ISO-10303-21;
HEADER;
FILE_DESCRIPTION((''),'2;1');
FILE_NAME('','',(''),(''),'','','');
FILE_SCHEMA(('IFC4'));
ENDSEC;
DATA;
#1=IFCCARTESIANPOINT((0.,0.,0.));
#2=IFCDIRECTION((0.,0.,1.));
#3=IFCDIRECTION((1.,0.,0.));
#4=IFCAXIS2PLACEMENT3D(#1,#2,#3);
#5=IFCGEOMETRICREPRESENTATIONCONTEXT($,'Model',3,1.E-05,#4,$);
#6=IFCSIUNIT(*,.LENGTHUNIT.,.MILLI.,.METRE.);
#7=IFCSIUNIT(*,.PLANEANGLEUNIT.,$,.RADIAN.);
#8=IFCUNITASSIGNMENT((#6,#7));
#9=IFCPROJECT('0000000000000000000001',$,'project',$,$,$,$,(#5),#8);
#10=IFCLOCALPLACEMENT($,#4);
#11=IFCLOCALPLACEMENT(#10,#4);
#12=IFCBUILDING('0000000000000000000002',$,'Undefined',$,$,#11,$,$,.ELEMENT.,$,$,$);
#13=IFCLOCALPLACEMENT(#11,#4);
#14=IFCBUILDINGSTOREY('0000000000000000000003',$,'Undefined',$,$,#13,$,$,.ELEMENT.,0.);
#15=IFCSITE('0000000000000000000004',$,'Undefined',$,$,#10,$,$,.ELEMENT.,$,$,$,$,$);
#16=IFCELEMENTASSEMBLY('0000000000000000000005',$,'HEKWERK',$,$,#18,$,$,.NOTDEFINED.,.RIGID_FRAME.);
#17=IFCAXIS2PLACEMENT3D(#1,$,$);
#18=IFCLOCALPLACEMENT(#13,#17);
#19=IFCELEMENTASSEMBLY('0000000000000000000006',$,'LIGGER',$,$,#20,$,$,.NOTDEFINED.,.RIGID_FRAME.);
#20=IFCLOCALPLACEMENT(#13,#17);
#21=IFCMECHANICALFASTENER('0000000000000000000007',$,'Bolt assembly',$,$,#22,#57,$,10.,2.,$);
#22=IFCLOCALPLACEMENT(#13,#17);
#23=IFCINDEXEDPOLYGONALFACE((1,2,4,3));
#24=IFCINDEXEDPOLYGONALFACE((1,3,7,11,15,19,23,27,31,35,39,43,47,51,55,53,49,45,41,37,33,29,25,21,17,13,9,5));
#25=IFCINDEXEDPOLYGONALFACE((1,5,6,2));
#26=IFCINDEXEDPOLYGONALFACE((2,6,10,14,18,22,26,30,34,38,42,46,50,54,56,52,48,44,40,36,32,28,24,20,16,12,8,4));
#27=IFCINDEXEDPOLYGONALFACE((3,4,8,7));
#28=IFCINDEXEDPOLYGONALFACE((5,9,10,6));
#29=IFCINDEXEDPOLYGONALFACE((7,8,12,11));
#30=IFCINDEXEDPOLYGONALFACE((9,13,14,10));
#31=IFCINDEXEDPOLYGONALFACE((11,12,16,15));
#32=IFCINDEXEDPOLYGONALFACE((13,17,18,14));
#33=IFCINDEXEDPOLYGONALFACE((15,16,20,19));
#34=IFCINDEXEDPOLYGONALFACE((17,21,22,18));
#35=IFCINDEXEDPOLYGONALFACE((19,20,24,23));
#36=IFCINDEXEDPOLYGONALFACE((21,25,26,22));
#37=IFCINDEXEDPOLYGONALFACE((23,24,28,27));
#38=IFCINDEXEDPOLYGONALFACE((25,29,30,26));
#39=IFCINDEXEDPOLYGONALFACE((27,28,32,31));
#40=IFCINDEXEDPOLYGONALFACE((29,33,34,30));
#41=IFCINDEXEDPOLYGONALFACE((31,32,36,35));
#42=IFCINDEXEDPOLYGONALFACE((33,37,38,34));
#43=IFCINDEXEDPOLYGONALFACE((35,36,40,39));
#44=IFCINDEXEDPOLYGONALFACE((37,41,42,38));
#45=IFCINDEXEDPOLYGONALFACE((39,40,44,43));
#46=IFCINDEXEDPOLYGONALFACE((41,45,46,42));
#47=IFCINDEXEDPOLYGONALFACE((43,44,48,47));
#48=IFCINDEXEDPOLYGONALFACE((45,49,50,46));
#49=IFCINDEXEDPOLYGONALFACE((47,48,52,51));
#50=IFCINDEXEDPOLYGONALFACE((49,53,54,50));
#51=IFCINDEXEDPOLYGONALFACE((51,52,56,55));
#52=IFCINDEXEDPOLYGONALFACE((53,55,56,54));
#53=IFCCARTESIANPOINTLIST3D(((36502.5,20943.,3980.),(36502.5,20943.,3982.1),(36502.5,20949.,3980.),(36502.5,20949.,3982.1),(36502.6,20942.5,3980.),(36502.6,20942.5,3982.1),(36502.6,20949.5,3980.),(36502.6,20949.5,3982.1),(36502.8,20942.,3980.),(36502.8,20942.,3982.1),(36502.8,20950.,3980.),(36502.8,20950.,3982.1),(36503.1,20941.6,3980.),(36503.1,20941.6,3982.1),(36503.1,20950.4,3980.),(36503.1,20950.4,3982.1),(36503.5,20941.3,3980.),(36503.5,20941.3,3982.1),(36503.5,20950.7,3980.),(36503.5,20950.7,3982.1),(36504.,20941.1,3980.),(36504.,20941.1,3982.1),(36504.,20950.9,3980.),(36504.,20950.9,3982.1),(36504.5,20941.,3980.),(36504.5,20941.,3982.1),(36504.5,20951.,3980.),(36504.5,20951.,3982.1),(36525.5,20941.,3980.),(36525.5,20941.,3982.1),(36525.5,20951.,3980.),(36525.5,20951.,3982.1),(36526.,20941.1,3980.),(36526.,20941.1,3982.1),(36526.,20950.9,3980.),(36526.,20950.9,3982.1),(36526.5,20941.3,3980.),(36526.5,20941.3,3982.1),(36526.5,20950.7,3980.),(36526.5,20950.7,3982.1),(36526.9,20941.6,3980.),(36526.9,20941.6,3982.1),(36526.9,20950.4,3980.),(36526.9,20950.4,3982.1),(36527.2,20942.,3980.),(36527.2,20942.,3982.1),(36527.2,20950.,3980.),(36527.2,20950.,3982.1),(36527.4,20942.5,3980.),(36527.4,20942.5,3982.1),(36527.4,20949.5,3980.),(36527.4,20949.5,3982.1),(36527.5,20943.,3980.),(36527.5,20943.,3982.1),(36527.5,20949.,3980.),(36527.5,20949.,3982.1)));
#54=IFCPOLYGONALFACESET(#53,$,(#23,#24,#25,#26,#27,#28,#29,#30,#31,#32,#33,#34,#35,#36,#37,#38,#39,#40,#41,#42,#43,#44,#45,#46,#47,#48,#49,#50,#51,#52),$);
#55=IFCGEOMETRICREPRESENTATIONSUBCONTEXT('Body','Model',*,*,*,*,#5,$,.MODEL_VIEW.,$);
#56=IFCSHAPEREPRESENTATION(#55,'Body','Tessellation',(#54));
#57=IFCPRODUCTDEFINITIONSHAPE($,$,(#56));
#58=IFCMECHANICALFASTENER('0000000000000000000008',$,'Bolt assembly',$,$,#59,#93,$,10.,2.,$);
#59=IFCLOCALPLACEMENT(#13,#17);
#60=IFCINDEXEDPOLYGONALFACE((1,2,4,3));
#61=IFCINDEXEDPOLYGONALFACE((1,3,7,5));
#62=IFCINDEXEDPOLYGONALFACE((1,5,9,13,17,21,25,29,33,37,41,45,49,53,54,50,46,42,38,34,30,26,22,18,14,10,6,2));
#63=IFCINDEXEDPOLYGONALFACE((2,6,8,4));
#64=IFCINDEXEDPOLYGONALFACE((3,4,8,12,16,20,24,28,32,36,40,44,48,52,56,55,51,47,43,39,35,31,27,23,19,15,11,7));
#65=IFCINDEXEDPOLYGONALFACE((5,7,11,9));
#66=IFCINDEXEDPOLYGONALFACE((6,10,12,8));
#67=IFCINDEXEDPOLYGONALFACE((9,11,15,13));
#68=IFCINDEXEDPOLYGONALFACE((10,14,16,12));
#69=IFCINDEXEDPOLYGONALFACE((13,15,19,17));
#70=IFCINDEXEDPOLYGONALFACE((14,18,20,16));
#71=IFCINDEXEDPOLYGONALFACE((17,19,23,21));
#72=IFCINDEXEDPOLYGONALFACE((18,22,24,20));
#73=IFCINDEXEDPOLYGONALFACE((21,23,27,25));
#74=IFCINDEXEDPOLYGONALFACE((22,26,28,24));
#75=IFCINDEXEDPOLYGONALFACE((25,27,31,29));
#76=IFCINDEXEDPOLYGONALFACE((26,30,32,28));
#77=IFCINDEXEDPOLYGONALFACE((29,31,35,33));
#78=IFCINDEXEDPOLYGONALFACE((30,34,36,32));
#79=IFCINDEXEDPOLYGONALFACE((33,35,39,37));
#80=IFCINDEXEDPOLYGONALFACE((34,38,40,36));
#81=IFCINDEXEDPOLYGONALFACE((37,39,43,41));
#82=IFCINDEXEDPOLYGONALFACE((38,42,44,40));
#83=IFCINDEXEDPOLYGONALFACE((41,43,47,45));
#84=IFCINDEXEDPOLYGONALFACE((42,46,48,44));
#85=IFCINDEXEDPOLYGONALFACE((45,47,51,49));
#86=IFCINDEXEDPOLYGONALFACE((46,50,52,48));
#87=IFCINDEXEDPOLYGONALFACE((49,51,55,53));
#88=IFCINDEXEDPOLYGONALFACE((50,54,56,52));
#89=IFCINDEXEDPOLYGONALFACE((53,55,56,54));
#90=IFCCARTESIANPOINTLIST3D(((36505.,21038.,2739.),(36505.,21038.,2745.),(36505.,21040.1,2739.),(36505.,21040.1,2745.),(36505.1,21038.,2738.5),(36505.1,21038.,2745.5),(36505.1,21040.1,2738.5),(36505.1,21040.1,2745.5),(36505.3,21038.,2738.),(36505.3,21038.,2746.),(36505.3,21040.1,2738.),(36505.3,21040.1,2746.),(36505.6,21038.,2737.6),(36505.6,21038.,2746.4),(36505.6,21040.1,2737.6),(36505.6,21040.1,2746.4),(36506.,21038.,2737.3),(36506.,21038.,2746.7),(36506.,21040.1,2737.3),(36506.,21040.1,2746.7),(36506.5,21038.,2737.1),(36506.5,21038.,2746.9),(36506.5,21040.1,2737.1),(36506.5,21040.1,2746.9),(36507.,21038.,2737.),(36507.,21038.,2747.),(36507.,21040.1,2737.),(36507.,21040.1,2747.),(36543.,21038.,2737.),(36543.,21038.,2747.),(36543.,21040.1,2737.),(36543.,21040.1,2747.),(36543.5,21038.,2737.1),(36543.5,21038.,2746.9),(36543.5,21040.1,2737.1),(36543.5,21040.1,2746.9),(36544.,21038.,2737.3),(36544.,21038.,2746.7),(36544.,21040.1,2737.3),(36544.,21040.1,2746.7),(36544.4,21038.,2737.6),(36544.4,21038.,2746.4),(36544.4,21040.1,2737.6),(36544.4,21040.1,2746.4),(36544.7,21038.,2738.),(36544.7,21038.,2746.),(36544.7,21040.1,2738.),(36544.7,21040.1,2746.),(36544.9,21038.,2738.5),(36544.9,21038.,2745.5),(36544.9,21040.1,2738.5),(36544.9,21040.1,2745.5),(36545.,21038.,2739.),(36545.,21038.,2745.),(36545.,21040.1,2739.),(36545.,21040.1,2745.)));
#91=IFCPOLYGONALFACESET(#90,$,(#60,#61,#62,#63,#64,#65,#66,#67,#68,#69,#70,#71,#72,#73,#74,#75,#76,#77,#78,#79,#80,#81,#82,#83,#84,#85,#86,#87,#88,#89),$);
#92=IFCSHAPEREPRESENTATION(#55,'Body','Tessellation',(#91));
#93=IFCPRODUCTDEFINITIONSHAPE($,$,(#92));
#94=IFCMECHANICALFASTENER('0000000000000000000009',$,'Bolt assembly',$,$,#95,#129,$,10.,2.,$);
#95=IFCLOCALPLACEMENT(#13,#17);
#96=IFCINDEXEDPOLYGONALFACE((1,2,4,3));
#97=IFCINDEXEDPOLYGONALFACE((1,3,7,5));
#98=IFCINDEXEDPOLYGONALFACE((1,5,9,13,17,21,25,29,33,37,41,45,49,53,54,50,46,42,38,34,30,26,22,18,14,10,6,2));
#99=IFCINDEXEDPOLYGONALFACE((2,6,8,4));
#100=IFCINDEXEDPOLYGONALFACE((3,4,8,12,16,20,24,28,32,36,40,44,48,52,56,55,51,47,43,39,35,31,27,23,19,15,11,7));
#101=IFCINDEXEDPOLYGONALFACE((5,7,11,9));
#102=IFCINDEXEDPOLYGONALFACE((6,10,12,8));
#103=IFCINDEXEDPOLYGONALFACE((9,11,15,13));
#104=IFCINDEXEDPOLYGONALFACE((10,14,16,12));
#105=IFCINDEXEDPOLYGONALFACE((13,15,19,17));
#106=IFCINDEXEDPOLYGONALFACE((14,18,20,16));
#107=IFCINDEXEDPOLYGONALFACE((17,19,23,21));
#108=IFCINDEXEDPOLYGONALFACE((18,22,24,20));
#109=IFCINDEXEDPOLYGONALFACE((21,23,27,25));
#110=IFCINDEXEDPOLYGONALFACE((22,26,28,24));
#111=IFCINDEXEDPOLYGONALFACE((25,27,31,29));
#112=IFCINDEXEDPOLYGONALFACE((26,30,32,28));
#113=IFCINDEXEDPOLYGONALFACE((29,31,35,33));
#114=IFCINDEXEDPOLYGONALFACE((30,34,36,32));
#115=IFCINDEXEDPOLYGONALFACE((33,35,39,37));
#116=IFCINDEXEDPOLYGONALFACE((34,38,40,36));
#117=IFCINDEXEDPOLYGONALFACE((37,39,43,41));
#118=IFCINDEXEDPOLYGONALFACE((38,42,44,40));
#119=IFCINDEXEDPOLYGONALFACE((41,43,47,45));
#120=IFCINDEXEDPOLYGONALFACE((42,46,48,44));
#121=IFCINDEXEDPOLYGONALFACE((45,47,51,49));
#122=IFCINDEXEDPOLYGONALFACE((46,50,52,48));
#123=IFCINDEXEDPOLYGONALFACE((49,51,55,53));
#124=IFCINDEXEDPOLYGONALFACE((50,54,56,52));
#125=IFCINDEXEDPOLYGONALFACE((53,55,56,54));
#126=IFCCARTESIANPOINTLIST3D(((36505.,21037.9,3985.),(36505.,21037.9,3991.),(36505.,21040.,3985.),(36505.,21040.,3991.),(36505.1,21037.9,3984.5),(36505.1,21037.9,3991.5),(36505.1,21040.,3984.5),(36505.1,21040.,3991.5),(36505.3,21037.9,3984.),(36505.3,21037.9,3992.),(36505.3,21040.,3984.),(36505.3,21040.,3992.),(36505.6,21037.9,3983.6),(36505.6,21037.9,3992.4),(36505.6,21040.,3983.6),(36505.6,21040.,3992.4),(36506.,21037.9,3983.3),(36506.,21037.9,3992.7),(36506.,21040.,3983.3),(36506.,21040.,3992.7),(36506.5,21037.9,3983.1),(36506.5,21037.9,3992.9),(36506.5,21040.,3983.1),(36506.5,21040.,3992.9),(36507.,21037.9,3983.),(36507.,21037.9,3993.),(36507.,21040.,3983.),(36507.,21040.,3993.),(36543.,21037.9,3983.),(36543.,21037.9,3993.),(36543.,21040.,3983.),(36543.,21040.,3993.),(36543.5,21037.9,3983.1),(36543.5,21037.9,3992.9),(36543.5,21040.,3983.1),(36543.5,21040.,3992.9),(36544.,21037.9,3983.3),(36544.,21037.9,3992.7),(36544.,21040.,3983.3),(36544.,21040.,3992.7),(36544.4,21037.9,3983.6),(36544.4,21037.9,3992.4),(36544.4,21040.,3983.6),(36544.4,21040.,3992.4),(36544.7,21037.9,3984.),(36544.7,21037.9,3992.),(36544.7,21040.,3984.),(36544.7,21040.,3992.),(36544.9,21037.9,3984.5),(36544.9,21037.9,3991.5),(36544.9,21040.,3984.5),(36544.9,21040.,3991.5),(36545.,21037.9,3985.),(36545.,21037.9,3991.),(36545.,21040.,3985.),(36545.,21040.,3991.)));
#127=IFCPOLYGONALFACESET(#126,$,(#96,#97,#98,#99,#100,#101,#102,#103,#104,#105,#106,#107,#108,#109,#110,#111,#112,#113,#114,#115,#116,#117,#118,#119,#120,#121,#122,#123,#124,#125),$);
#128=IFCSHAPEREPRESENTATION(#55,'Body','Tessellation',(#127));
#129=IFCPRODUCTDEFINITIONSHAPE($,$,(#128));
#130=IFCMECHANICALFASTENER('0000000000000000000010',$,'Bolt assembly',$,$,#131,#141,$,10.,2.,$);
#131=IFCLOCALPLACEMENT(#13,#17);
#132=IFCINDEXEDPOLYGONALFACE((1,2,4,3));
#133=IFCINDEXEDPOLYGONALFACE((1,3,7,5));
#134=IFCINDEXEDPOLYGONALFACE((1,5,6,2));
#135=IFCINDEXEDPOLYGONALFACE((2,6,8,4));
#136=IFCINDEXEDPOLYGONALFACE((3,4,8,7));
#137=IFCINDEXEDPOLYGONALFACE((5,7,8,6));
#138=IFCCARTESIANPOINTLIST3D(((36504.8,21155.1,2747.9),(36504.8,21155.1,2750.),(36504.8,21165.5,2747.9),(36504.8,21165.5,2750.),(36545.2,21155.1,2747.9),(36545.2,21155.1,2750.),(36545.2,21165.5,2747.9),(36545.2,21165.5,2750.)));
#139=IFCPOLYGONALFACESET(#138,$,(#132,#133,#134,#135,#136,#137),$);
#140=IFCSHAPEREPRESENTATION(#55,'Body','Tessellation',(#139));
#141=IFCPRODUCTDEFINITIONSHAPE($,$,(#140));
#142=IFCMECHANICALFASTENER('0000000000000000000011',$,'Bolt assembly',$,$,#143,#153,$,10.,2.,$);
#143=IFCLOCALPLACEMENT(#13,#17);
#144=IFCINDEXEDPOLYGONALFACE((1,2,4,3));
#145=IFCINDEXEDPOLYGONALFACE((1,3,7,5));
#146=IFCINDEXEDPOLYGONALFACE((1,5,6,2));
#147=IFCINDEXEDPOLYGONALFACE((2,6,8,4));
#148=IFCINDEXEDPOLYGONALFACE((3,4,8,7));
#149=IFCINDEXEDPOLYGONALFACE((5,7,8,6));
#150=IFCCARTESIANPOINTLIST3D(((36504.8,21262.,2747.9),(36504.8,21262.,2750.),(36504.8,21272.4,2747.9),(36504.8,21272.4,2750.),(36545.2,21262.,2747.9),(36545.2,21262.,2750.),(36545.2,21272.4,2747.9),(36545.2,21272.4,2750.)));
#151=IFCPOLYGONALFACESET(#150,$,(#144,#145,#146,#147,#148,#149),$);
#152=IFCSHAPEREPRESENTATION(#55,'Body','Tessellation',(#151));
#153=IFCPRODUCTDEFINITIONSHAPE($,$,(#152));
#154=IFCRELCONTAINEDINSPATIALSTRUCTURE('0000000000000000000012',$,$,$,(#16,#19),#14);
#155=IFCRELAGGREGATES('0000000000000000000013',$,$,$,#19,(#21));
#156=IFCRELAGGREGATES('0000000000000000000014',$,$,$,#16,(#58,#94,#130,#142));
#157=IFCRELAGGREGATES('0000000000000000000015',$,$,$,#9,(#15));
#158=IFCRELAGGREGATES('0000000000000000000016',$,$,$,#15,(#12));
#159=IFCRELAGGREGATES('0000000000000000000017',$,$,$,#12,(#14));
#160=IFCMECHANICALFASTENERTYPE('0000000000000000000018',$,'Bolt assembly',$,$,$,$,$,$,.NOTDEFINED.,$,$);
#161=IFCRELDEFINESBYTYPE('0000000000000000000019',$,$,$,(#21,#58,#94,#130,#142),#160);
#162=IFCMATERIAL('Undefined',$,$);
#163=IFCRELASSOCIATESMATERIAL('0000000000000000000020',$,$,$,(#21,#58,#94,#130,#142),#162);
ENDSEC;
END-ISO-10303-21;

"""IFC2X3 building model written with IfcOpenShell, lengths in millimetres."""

from ifc_helpers import new_model, si_unit, frame, frame_2d, origin_with_axes, place, context, subcontext, project, spatial, polyline, circle_curve, parameter, trimmed, segment, composite_curve, outline, extrude, source, transform, mapped, material, type_object, element, aggregate, save


model = new_model("IFC2X3")

# Units and contexts
model_context = context("Model", 3, precision=1e-05, world=origin_with_axes())
body_context = subcontext(model_context, "Body", "Model", "MODEL_VIEW")
ifc_project = project(units=[si_unit("LENGTHUNIT", "METRE", prefix="MILLI"), si_unit("PLANEANGLEUNIT", "RADIAN")], contexts=[model_context])

# Site, building, storey
site_placement = place(None, origin_with_axes())
site = spatial("IfcSite", under=ifc_project, at=site_placement, Name="Undefined", CompositionType="ELEMENT")
building_placement = place(site_placement, origin_with_axes())
building = spatial("IfcBuilding", under=site, at=building_placement, Name="Undefined", CompositionType="ELEMENT")
storey_placement = place(building_placement, origin_with_axes())
storey = spatial("IfcBuildingStorey", under=building, at=storey_placement, Name="Undefined", CompositionType="ELEMENT", Elevation=0.0)

# Element assemblies
assembly_1_placement = place(storey_placement, origin_with_axes())
assembly_1 = element("IfcElementAssembly", 1, at=assembly_1_placement, inside=storey, Name="HEKWERK", AssemblyPlace="NOTDEFINED", PredefinedType="RIGID_FRAME")
assembly_2_placement = place(storey_placement, origin_with_axes())
assembly_2 = element("IfcElementAssembly", 2, at=assembly_2_placement, inside=storey, Name="LIGGER", AssemblyPlace="NOTDEFINED", PredefinedType="RIGID_FRAME")

# Shared definitions
ifc_material_1 = material(Name="Undefined")
mechanical_fastener_type = type_object("IfcMechanicalFastenerType", Name="Bolt assembly")

# Mechanical fasteners
shared_shape_1 = source(origin_with_axes(), body_context, "Body", "SweptSolid", [
    extrude(outline(composite_curve([segment(polyline([(-3.0, 12.5), (3.0, 12.5)]), True, "CONTINUOUS"), segment(trimmed(circle_curve(frame_2d((3.0, 10.5), x_axis=(0.0, 1.0)), 2.0), [parameter(0.0)], [parameter(4.712389)], False, "PARAMETER"), True, "CONTINUOUS"), segment(polyline([(5.0, 10.5), (5.0, -10.5)]), True, "CONTINUOUS"), segment(trimmed(circle_curve(frame_2d((3.0, -10.5), x_axis=(1.0, 0.0)), 2.0), [parameter(0.0)], [parameter(4.712389)], False, "PARAMETER"), True, "CONTINUOUS"), segment(polyline([(3.0, -12.5), (-3.0, -12.5)]), True, "CONTINUOUS"), segment(trimmed(circle_curve(frame_2d((-3.0, -10.5), x_axis=(0.0, -1.0)), 2.0), [parameter(0.0)], [parameter(4.712389)], False, "PARAMETER"), True, "CONTINUOUS"), segment(polyline([(-5.0, -10.5), (-5.0, 10.5)]), True, "CONTINUOUS"), segment(trimmed(circle_curve(frame_2d((-3.0, 10.5), x_axis=(-1.0, 0.0)), 2.0), [parameter(0.0)], [parameter(4.712389)], False, "PARAMETER"), True, "DISCONTINUOUS")], self_intersect=False)), frame((0.0, 0.0, 0.0), z_axis=(0.0, 1.0, 0.0), x_axis=(1.0, 0.0, 0.0)), (0.0, 0.0, 1.0), 2.1),
])
mechanical_fastener_1_placement = place(assembly_2_placement, frame((36515.0, 20946.0, 3980.0), z_axis=(-1.0, 0.0, 0.0), x_axis=(0.0, -1.0, 0.0)))
mechanical_fastener_1 = element("IfcMechanicalFastener", 3, at=mechanical_fastener_1_placement, type_object=mechanical_fastener_type, material=ifc_material_1, Name="Bolt assembly", NominalDiameter=10.0, NominalLength=2.0, context=body_context, shape_type="MappedRepresentation", body=[
    mapped(shared_shape_1, transform((0.0, 0.0, 0.0))),
])
shared_shape_2 = source(origin_with_axes(), body_context, "Body", "SweptSolid", [
    extrude(outline(composite_curve([segment(polyline([(-3.0, 20.0), (3.0, 20.0)]), True, "CONTINUOUS"), segment(trimmed(circle_curve(frame_2d((3.0, 18.0), x_axis=(0.0, 1.0)), 2.0), [parameter(0.0)], [parameter(4.712389)], False, "PARAMETER"), True, "CONTINUOUS"), segment(polyline([(5.0, 18.0), (5.0, -18.0)]), True, "CONTINUOUS"), segment(trimmed(circle_curve(frame_2d((3.0, -18.0), x_axis=(1.0, 0.0)), 2.0), [parameter(0.0)], [parameter(4.712389)], False, "PARAMETER"), True, "CONTINUOUS"), segment(polyline([(3.0, -20.0), (-3.0, -20.0)]), True, "CONTINUOUS"), segment(trimmed(circle_curve(frame_2d((-3.0, -18.0), x_axis=(0.0, -1.0)), 2.0), [parameter(0.0)], [parameter(4.712389)], False, "PARAMETER"), True, "CONTINUOUS"), segment(polyline([(-5.0, -18.0), (-5.0, 18.0)]), True, "CONTINUOUS"), segment(trimmed(circle_curve(frame_2d((-3.0, 18.0), x_axis=(-1.0, 0.0)), 2.0), [parameter(0.0)], [parameter(4.712389)], False, "PARAMETER"), True, "DISCONTINUOUS")], self_intersect=False)), frame((0.0, 0.0, 0.0), z_axis=(0.0, 1.0, 0.0), x_axis=(1.0, 0.0, 0.0)), (0.0, 0.0, 1.0), 2.1),
])
mechanical_fastener_2_placement = place(assembly_1_placement, frame((36525.0, 21038.0, 2742.0), z_axis=(-1.0, 0.0, 0.0), x_axis=(0.0, 0.0, 1.0)))
mechanical_fastener_2 = element("IfcMechanicalFastener", 4, at=mechanical_fastener_2_placement, type_object=mechanical_fastener_type, material=ifc_material_1, Name="Bolt assembly", NominalDiameter=10.0, NominalLength=2.0, context=body_context, shape_type="MappedRepresentation", body=[
    mapped(shared_shape_2, transform((0.0, 0.0, 0.0))),
])
shared_shape_3 = source(origin_with_axes(), body_context, "Body", "SweptSolid", [
    extrude(outline(composite_curve([segment(polyline([(-3.0, 20.0), (3.0, 20.0)]), True, "CONTINUOUS"), segment(trimmed(circle_curve(frame_2d((3.0, 18.0), x_axis=(0.0, 1.0)), 2.0), [parameter(0.0)], [parameter(4.712389)], False, "PARAMETER"), True, "CONTINUOUS"), segment(polyline([(5.0, 18.0), (5.0, -18.0)]), True, "CONTINUOUS"), segment(trimmed(circle_curve(frame_2d((3.0, -18.0), x_axis=(1.0, 0.0)), 2.0), [parameter(0.0)], [parameter(4.712389)], False, "PARAMETER"), True, "CONTINUOUS"), segment(polyline([(3.0, -20.0), (-3.0, -20.0)]), True, "CONTINUOUS"), segment(trimmed(circle_curve(frame_2d((-3.0, -18.0), x_axis=(0.0, -1.0)), 2.0), [parameter(0.0)], [parameter(4.712389)], False, "PARAMETER"), True, "CONTINUOUS"), segment(polyline([(-5.0, -18.0), (-5.0, 18.0)]), True, "CONTINUOUS"), segment(trimmed(circle_curve(frame_2d((-3.0, 18.0), x_axis=(-1.0, 0.0)), 2.0), [parameter(0.0)], [parameter(4.712389)], False, "PARAMETER"), True, "DISCONTINUOUS")], self_intersect=False)), frame((0.0, -2.0, 0.0), z_axis=(0.0, 1.0, 0.0), x_axis=(1.0, 0.0, 0.0)), (0.0, 0.0, 1.0), 2.1),
])
mechanical_fastener_3_placement = place(assembly_1_placement, frame((36525.0, 21038.0, 3988.0), z_axis=(-1.0, 0.0, 0.0), x_axis=(0.0, 0.0, -1.0)))
mechanical_fastener_3 = element("IfcMechanicalFastener", 5, at=mechanical_fastener_3_placement, type_object=mechanical_fastener_type, material=ifc_material_1, Name="Bolt assembly", NominalDiameter=10.0, NominalLength=2.0, context=body_context, shape_type="MappedRepresentation", body=[
    mapped(shared_shape_3, transform((0.0, 0.0, 0.0))),
])
shared_shape_4 = source(origin_with_axes(), body_context, "Body", "SweptSolid", [
    extrude(outline(composite_curve([segment(polyline([(-20.2, 5.2), (20.2, 5.2)]), True, "CONTINUOUS"), segment(polyline([(20.2, 5.2), (20.2, -5.2)]), True, "CONTINUOUS"), segment(polyline([(20.2, -5.2), (-20.2, -5.2)]), True, "CONTINUOUS"), segment(polyline([(-20.2, -5.2), (-20.2, 5.2)]), True, "CONTINUOUS")], self_intersect=False)), frame((0.0, -1.0, 0.0), z_axis=(0.0, 1.0, 0.0), x_axis=(1.0, 0.0, 0.0)), (0.0, 0.0, 1.0), 2.1),
])
mechanical_fastener_4_placement = place(assembly_1_placement, frame((36525.0, 21160.3, 2749.0), z_axis=(0.0, 1.0, 0.0), x_axis=(1.0, 0.0, 0.0)))
mechanical_fastener_4 = element("IfcMechanicalFastener", 6, at=mechanical_fastener_4_placement, type_object=mechanical_fastener_type, material=ifc_material_1, Name="Bolt assembly", NominalDiameter=10.0, NominalLength=2.0, context=body_context, shape_type="MappedRepresentation", body=[
    mapped(shared_shape_4, transform((0.0, 0.0, 0.0))),
])
shared_shape_5 = source(origin_with_axes(), body_context, "Body", "SweptSolid", [
    extrude(outline(composite_curve([segment(polyline([(-20.2, 5.2), (20.2, 5.2)]), True, "CONTINUOUS"), segment(polyline([(20.2, 5.2), (20.2, -5.2)]), True, "CONTINUOUS"), segment(polyline([(20.2, -5.2), (-20.2, -5.2)]), True, "CONTINUOUS"), segment(polyline([(-20.2, -5.2), (-20.2, 5.2)]), True, "CONTINUOUS")], self_intersect=False)), frame((0.0, -1.0, 0.0), z_axis=(0.0, 1.0, 0.0), x_axis=(1.0, 0.0, 0.0)), (0.0, 0.0, 1.0), 2.1),
])
mechanical_fastener_5_placement = place(assembly_1_placement, frame((36525.0, 21267.2, 2749.0), z_axis=(0.0, 1.0, 0.0), x_axis=(1.0, 0.0, 0.0)))
mechanical_fastener_5 = element("IfcMechanicalFastener", 7, at=mechanical_fastener_5_placement, type_object=mechanical_fastener_type, material=ifc_material_1, Name="Bolt assembly", NominalDiameter=10.0, NominalLength=2.0, context=body_context, shape_type="MappedRepresentation", body=[
    mapped(shared_shape_5, transform((0.0, 0.0, 0.0))),
])
aggregate(assembly_2, [mechanical_fastener_1])
aggregate(assembly_1, [mechanical_fastener_2, mechanical_fastener_3, mechanical_fastener_4, mechanical_fastener_5])

save(model, "model.ifc")
